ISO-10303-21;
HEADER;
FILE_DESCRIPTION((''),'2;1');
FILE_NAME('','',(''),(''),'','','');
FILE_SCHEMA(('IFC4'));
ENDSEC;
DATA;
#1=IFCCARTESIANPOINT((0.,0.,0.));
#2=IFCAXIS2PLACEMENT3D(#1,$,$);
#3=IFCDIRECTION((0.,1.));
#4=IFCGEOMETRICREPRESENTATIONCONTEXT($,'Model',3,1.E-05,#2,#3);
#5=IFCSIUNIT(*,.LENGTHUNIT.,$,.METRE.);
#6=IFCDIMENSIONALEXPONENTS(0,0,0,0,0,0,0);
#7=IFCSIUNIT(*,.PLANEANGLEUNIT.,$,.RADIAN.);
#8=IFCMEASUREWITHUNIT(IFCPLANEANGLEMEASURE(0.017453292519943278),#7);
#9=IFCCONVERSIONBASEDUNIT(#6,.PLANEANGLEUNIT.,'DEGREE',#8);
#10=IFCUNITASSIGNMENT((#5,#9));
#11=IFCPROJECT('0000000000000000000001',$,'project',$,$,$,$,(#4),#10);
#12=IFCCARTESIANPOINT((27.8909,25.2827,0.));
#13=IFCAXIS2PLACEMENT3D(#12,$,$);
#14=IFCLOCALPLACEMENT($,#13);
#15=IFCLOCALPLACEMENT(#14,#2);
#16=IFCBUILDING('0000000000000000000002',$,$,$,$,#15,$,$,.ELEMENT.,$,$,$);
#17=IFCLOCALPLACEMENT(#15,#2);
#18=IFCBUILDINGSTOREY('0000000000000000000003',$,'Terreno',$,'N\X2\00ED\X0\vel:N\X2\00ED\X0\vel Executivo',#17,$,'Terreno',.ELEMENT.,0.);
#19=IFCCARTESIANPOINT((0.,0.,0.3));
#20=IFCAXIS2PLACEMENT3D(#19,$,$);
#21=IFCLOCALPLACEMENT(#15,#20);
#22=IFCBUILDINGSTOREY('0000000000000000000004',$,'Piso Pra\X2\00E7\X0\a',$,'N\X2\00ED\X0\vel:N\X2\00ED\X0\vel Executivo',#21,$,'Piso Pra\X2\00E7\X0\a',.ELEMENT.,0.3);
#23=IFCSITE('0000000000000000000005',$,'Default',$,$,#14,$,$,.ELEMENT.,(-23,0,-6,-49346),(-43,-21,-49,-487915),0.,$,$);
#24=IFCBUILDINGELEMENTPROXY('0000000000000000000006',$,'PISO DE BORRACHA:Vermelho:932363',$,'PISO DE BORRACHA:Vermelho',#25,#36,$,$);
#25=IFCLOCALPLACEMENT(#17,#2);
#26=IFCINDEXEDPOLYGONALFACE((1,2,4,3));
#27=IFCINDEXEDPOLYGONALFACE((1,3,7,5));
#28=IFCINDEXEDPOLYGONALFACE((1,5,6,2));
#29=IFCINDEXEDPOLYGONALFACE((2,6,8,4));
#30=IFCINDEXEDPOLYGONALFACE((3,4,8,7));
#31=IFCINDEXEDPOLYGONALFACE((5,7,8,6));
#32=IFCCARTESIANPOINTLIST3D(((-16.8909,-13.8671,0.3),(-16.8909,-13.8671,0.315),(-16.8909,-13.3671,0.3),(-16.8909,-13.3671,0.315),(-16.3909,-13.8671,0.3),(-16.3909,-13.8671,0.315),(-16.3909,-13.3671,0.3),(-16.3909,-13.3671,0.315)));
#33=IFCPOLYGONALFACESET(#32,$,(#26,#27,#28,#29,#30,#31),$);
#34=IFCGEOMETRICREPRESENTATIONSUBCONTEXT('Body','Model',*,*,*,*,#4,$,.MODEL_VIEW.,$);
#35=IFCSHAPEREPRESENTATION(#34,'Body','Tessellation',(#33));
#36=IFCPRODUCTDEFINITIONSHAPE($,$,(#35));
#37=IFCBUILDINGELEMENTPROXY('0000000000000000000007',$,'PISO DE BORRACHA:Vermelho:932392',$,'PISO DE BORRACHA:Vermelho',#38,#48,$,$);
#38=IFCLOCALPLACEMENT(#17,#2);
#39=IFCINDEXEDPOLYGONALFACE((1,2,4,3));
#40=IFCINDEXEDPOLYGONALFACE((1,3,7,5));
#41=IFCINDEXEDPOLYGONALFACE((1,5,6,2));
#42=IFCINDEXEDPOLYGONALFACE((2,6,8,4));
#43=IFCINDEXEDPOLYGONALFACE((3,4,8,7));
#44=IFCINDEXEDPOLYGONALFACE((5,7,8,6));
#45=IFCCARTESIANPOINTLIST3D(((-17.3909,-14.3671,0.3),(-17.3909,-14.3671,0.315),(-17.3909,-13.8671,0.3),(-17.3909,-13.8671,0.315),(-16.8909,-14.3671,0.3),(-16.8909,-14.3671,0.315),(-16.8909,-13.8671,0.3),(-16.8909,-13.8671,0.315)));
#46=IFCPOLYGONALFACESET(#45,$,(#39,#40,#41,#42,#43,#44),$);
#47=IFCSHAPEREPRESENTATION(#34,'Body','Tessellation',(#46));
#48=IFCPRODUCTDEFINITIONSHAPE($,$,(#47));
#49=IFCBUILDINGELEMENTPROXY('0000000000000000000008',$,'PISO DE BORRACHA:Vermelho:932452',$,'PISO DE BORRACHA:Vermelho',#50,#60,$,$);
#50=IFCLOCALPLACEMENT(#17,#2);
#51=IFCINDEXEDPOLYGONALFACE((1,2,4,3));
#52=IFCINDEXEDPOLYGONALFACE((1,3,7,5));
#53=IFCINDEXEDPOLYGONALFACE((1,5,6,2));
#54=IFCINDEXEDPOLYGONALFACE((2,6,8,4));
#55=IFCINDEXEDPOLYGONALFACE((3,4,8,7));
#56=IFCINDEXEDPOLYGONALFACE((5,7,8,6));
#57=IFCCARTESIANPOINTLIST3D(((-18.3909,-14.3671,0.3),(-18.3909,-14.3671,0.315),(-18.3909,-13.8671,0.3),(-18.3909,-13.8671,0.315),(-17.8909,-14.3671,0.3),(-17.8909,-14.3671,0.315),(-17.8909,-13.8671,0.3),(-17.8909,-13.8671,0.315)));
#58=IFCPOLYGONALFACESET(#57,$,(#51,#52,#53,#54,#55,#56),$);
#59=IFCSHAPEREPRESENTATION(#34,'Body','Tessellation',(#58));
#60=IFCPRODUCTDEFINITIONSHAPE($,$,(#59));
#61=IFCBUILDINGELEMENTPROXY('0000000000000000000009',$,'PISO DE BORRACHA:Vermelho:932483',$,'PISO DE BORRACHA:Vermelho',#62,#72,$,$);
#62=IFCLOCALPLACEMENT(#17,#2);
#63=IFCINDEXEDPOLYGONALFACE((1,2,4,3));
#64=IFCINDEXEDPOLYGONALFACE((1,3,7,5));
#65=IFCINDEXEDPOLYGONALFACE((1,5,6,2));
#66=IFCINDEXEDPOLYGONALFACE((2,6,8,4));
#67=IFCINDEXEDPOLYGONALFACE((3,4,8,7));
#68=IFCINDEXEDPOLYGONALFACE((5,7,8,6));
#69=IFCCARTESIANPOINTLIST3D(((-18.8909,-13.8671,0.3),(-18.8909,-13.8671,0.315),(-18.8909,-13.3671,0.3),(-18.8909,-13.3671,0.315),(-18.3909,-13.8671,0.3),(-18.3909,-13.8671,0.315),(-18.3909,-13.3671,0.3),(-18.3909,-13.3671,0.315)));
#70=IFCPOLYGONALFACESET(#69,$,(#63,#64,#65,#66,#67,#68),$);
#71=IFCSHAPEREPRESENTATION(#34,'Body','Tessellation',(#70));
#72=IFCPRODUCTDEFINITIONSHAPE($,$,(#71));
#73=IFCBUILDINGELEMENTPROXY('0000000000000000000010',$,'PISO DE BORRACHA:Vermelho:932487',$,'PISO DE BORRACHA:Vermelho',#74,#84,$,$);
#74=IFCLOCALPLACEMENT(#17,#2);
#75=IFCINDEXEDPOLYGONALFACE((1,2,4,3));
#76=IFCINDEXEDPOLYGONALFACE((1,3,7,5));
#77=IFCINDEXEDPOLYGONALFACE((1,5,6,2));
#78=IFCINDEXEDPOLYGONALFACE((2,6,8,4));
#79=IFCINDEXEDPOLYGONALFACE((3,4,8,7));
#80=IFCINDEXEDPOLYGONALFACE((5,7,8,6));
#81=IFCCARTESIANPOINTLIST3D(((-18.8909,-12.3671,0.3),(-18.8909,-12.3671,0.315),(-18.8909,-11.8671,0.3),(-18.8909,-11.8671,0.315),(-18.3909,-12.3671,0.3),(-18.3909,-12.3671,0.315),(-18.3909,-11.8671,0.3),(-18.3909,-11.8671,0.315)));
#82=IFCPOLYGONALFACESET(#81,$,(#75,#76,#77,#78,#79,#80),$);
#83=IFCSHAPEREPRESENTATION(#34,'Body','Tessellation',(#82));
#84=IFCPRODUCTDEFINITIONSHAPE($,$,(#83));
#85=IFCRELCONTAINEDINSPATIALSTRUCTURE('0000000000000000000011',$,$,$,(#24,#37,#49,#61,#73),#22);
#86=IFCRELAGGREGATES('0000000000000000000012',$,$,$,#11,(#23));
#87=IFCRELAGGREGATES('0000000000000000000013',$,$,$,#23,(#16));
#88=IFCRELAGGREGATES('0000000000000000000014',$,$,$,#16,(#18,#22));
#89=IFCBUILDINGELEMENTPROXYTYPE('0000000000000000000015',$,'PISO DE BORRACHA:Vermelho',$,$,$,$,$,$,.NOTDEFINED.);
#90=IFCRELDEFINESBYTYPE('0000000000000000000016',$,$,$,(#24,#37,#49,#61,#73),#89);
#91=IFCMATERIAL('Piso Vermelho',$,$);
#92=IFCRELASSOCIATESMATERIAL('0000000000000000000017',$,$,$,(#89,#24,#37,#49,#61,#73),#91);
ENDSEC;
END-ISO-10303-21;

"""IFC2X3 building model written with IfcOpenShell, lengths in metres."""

from ifc_helpers import new_model, entity, si_unit, converted_unit, direction, frame, origin, origin_2d_with_axis, place, context, subcontext, project, spatial, rectangle, extrude, source, transform, mapped, material, type_object, type_shapes, element, save


model = new_model("IFC2X3")

# Units and contexts
model_context = context("Model", 3, precision=1e-05, world=origin(), true_north=direction((0.0, 1.0)))
body_context = subcontext(model_context, "Body", "Model", "MODEL_VIEW")
ifc_project = project(units=[si_unit("LENGTHUNIT", "METRE"), converted_unit("PLANEANGLEUNIT", "DEGREE", entity("IfcPlaneAngleMeasure", 0.017453292519943278), si_unit("PLANEANGLEUNIT", "RADIAN"), dimensions=[0, 0, 0, 0, 0, 0, 0])], contexts=[model_context])

# Site, building, storey
site_placement = place(None, frame((27.8909, 25.2827, 0.0)))
site = spatial("IfcSite", under=ifc_project, at=site_placement, Name="Default", CompositionType="ELEMENT", RefLatitude=(-23, 0, -6, -49346), RefLongitude=(-43, -21, -49, -487915), RefElevation=0.0)
building_placement = place(site_placement, origin())
building = spatial("IfcBuilding", under=site, at=building_placement, CompositionType="ELEMENT")
storey_1_placement = place(building_placement, origin())
storey_1 = spatial("IfcBuildingStorey", under=building, at=storey_1_placement, Name="Terreno", ObjectType="Nível:Nível Executivo", LongName="Terreno", CompositionType="ELEMENT", Elevation=0.0)

# Shared definitions
storey_2_placement = place(building_placement, frame((0.0, 0.0, 0.3)))
storey_2 = spatial("IfcBuildingStorey", under=building, at=storey_2_placement, Name="Piso Praça", ObjectType="Nível:Nível Executivo", LongName="Piso Praça", CompositionType="ELEMENT", Elevation=0.3)

# Building element proxies
ifc_material_1 = material(Name="Piso Vermelho")
building_element_proxy_type_1 = type_object("IfcBuildingElementProxyType", Name="PISO DE BORRACHA:Vermelho", PredefinedType="NOTDEFINED", material=ifc_material_1)
shared_shape_1 = source(origin(), body_context, "Body", "SweptSolid", [
    extrude(rectangle(XDim=0.5, YDim=0.5, at=origin_2d_with_axis()), frame((0.25, 0.25, 0.0), z_axis=(0.0, 0.0, 1.0), x_axis=(-1.0, 0.0, 0.0)), (0.0, 0.0, 1.0), 0.015),
])
type_shapes(building_element_proxy_type_1, [shared_shape_1])
for number, where, z_axis, x_axis, name in (
    (1, (-16.8909, -13.3671, 0.0), (0.0, 0.0, 1.0), (0.0, -1.0, 0.0), "PISO DE BORRACHA:Vermelho:932363"),
    (2, (-17.3909, -13.8671, 0.0), (0.0, 0.0, 1.0), (0.0, -1.0, 0.0), "PISO DE BORRACHA:Vermelho:932392"),
    (3, (-18.3909, -13.8671, 0.0), (0.0, 0.0, 1.0), (0.0, -1.0, 0.0), "PISO DE BORRACHA:Vermelho:932452"),
    (4, (-18.8909, -13.3671, 0.0), (0.0, 0.0, 1.0), (0.0, -1.0, 0.0), "PISO DE BORRACHA:Vermelho:932483"),
    (5, (-18.8909, -11.8671, 0.0), (0.0, 0.0, 1.0), (0.0, -1.0, 0.0), "PISO DE BORRACHA:Vermelho:932487"),
):
    element("IfcBuildingElementProxy", number, at=place(storey_2_placement, frame(where, z_axis=z_axis, x_axis=x_axis)), inside=storey_2, type_object=building_element_proxy_type_1, material=ifc_material_1, Name=name, ObjectType="PISO DE BORRACHA:Vermelho", context=body_context, shape_type="MappedRepresentation", body=[
        mapped(shared_shape_1, transform((0.0, 0.0, 0.0), scale=1.0)),
    ])

save(model, "model.ifc")
